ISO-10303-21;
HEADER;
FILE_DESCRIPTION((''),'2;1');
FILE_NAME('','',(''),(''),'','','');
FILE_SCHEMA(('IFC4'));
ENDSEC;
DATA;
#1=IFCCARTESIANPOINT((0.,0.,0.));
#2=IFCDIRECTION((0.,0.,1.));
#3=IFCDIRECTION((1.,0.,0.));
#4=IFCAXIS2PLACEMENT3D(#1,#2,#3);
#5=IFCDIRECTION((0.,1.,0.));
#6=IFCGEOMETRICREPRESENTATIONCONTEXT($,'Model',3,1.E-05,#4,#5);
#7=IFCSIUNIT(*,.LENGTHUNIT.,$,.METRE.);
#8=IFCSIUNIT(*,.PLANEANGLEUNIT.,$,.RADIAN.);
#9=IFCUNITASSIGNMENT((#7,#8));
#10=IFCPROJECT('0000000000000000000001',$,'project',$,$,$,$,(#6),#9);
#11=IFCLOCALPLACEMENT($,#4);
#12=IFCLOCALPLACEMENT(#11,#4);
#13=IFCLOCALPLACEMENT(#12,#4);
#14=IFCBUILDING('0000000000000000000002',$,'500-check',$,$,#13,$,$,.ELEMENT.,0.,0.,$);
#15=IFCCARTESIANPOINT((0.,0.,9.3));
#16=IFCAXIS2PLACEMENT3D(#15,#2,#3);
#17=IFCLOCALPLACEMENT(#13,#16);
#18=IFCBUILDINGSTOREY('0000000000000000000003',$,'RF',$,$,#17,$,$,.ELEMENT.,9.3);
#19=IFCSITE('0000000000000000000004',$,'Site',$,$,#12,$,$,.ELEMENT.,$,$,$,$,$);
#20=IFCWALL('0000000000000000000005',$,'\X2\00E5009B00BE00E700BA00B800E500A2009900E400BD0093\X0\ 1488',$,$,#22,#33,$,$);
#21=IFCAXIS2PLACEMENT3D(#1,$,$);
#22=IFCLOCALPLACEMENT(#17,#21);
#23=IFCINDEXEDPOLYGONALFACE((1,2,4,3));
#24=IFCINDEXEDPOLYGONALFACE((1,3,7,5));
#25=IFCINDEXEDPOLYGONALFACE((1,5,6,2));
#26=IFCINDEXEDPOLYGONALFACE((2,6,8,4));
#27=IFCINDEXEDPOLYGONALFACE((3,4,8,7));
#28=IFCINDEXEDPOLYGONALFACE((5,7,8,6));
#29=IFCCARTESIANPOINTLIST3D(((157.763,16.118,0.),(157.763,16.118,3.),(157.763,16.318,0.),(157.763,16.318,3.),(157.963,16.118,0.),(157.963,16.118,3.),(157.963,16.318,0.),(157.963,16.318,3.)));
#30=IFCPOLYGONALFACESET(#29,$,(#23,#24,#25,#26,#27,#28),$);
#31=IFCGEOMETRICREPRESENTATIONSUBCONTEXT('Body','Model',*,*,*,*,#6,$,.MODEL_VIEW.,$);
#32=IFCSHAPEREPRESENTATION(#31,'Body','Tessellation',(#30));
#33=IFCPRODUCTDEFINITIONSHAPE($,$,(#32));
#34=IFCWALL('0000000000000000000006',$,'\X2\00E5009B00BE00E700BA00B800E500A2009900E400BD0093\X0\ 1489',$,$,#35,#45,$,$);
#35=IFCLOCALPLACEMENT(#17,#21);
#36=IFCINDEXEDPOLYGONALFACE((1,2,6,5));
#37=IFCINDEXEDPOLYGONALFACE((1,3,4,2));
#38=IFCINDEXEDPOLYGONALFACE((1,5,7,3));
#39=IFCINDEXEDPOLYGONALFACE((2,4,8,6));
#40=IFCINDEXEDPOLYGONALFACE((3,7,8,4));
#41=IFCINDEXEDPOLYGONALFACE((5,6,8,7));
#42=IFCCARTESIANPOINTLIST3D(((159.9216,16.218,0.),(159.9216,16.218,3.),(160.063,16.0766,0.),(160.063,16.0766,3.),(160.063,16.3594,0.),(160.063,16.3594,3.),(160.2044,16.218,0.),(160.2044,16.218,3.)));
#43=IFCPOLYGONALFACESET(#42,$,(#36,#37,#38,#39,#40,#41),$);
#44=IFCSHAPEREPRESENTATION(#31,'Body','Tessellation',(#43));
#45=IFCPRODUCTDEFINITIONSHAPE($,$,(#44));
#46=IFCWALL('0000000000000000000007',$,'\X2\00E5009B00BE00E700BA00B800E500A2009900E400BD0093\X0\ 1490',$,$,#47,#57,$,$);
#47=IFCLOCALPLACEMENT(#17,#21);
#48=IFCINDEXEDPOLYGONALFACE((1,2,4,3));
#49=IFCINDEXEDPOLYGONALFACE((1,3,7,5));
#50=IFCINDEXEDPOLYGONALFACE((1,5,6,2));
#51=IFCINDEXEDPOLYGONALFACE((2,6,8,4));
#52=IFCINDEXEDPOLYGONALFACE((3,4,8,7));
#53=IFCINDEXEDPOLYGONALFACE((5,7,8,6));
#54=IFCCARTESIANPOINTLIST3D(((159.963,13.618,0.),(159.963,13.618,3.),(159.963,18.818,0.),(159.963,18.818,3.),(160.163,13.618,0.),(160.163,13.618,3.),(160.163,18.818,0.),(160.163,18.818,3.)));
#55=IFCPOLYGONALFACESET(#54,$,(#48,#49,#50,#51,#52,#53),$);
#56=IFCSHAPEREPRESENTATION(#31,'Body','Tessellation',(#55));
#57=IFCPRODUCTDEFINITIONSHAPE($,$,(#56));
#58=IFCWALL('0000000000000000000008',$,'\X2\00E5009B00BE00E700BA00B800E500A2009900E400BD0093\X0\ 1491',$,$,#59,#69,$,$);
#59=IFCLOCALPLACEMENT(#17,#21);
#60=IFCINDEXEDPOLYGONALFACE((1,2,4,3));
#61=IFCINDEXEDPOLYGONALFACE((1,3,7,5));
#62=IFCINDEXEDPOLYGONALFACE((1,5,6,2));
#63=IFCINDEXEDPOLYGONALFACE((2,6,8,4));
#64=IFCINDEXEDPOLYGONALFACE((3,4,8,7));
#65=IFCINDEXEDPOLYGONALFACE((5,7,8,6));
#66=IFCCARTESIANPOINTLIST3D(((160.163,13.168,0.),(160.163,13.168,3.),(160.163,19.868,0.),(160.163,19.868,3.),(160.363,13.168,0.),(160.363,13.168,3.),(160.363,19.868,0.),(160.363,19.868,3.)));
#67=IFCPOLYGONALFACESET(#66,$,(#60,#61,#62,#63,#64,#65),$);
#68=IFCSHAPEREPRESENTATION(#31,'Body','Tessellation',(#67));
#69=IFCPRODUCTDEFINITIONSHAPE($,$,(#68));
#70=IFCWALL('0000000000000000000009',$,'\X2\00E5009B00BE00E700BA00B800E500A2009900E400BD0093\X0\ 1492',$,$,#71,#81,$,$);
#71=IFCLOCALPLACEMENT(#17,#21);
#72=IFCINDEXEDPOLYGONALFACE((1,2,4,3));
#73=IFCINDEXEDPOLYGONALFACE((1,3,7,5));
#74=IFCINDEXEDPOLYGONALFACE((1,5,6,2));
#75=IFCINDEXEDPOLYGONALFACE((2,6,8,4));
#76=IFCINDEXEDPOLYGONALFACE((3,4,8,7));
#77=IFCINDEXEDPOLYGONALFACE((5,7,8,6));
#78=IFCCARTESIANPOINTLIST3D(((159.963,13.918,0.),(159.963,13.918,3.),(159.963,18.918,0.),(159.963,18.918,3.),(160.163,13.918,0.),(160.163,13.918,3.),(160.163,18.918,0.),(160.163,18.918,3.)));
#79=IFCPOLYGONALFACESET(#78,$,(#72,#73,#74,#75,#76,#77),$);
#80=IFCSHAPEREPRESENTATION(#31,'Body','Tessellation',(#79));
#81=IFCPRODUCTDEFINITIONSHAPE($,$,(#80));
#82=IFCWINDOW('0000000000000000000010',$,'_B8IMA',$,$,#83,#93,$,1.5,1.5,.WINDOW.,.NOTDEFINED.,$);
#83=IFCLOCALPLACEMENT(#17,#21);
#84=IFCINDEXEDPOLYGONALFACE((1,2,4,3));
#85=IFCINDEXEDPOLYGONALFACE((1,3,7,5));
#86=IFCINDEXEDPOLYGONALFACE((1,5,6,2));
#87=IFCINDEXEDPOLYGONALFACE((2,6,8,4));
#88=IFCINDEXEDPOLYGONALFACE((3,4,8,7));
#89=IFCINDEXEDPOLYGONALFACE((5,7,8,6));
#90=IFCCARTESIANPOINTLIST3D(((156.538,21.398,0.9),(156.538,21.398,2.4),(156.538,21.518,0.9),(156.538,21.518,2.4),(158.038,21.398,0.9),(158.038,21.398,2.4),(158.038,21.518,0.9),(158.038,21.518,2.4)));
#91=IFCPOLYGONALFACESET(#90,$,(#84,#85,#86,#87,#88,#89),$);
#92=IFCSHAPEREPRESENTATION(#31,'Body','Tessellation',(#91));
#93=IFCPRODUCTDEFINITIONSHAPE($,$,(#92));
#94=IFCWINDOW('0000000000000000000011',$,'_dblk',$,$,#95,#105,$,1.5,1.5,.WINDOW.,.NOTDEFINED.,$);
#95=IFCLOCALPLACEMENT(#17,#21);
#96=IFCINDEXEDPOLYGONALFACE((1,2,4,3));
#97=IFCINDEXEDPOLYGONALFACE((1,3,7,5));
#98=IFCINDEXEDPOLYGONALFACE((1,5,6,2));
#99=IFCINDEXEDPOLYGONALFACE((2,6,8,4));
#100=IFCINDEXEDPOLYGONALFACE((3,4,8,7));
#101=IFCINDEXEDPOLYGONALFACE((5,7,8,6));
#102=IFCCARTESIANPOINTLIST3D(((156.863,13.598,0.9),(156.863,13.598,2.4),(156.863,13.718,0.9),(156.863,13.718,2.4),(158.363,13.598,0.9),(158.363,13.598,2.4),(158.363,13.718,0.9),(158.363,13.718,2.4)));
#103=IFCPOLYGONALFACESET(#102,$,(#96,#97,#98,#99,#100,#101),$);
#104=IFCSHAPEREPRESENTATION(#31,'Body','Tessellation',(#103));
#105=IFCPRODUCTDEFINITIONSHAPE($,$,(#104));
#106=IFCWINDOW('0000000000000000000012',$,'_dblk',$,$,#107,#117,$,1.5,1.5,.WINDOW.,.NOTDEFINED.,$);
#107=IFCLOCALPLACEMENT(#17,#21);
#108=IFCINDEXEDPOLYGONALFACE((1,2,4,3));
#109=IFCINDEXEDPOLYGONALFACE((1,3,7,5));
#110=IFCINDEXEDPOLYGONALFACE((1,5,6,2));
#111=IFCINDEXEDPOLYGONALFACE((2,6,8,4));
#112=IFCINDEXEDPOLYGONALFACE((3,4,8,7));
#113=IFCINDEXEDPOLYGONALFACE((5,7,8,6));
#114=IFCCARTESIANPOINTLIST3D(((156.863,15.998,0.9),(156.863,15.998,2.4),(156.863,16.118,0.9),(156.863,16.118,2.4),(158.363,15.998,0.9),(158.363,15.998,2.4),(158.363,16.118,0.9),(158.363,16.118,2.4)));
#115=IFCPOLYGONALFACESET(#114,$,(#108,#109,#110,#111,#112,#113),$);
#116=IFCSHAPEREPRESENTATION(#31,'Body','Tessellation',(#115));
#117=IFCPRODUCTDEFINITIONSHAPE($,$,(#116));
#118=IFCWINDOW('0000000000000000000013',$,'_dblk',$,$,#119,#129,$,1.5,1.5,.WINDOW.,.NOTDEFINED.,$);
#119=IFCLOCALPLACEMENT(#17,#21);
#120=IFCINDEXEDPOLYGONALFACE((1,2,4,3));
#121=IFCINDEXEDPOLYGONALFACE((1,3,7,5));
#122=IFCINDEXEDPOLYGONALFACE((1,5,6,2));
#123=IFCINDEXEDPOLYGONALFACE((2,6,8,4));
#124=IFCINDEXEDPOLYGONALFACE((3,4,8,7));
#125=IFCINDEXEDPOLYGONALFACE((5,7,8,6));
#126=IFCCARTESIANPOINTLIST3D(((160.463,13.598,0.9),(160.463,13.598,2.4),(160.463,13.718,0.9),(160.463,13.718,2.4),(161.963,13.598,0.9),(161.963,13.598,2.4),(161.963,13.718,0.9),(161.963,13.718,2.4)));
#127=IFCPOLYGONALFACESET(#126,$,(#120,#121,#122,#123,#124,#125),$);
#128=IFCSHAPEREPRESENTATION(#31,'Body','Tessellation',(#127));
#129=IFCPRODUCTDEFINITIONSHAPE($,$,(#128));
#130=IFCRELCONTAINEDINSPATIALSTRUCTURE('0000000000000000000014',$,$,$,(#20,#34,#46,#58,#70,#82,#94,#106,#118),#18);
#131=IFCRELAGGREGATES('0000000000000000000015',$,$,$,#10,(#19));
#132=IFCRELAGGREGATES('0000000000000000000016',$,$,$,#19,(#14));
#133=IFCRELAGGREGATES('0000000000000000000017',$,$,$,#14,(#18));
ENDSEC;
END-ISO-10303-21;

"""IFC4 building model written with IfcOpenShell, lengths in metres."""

from ifc_helpers import new_model, si_unit, direction, frame, frame_2d, origin_with_axes, place, context, subcontext, project, spatial, rectangle, extrude, element, save


model = new_model("IFC4")

# Units and contexts
model_context = context("Model", 3, precision=1e-05, world=origin_with_axes(), true_north=direction((0.0, 1.0, 0.0)))
body_context = subcontext(model_context, "Body", "Model", "MODEL_VIEW")
ifc_project = project(units=[si_unit("LENGTHUNIT", "METRE"), si_unit("PLANEANGLEUNIT", "RADIAN")], contexts=[model_context])

# Site, building, storey
placement = place(None, origin_with_axes())
site_placement = place(placement, origin_with_axes())
site = spatial("IfcSite", under=ifc_project, at=site_placement, Name="Site", CompositionType="ELEMENT")
building_placement = place(site_placement, origin_with_axes())
building = spatial("IfcBuilding", under=site, at=building_placement, Name="500-check", CompositionType="ELEMENT", ElevationOfRefHeight=0.0, ElevationOfTerrain=0.0)
storey_placement = place(building_placement, frame((0.0, 0.0, 9.3), z_axis=(0.0, 0.0, 1.0), x_axis=(1.0, 0.0, 0.0)))
storey = spatial("IfcBuildingStorey", under=building, at=storey_placement, Name="RF", CompositionType="ELEMENT", Elevation=9.3)

# Walls
for number, where, z_axis, x_axis, name in (
    (1, (157.863, 16.218, 0.0), (0.0, 0.0, 1.0), (0.0, -1.0, 0.0), "å\u009b¾çº¸å¢\u0099ä½\u0093 1488"),
    (2, (160.063, 16.218, 0.0), (0.0, 0.0, 1.0), (-0.707107, -0.707107, 0.0), "å\u009b¾çº¸å¢\u0099ä½\u0093 1489"),
):
    element("IfcWall", number, at=place(storey_placement, frame(where, z_axis=z_axis, x_axis=x_axis)), inside=storey, Name=name, context=body_context, shape_type="SweptSolid", body=[
        extrude(rectangle(XDim=0.2, YDim=0.2, at=frame_2d((0.0, 0.0), x_axis=(1.0, 0.0, 0.0))), frame((0.0, 0.0, 0.0), z_axis=(0.0, 0.0, 1.0)), (0.0, 0.0, 1.0), 3.0),
    ])
wall_1_placement = place(storey_placement, frame((160.063, 16.218, 0.0), z_axis=(0.0, 0.0, 1.0), x_axis=(0.0, 1.0, 0.0)))
element("IfcWall", 3, at=wall_1_placement, inside=storey, Name="å\u009b¾çº¸å¢\u0099ä½\u0093 1490", context=body_context, shape_type="SweptSolid", body=[
    extrude(rectangle(XDim=5.2, YDim=0.2, at=frame_2d((0.0, 0.0), x_axis=(1.0, 0.0, 0.0))), frame((0.0, 0.0, 0.0), z_axis=(0.0, 0.0, 1.0)), (0.0, 0.0, 1.0), 3.0),
])
wall_2_placement = place(storey_placement, frame((160.263, 16.518, 0.0), z_axis=(0.0, 0.0, 1.0), x_axis=(0.0, 1.0, 0.0)))
element("IfcWall", 4, at=wall_2_placement, inside=storey, Name="å\u009b¾çº¸å¢\u0099ä½\u0093 1491", context=body_context, shape_type="SweptSolid", body=[
    extrude(rectangle(XDim=6.7, YDim=0.2, at=frame_2d((0.0, 0.0), x_axis=(1.0, 0.0, 0.0))), frame((0.0, 0.0, 0.0), z_axis=(0.0, 0.0, 1.0)), (0.0, 0.0, 1.0), 3.0),
])
wall_3_placement = place(storey_placement, frame((160.063, 16.418, 0.0), z_axis=(0.0, 0.0, 1.0), x_axis=(0.0, 1.0, 0.0)))
element("IfcWall", 5, at=wall_3_placement, inside=storey, Name="å\u009b¾çº¸å¢\u0099ä½\u0093 1492", context=body_context, shape_type="SweptSolid", body=[
    extrude(rectangle(XDim=5.0, YDim=0.2, at=frame_2d((0.0, 0.0), x_axis=(1.0, 0.0, 0.0))), frame((0.0, 0.0, 0.0), z_axis=(0.0, 0.0, 1.0)), (0.0, 0.0, 1.0), 3.0),
])

# Windows
for number, where, z_axis, x_axis, name in (
    (6, (157.288, 21.458, 0.9), (0.0, 0.0, 1.0), (1.0, 0.0, 0.0), "_B8IMA"),
    (7, (157.613, 13.658, 0.9), (0.0, 0.0, 1.0), (1.0, 0.0, 0.0), "_dblk"),
    (8, (157.613, 16.058, 0.9), (0.0, 0.0, 1.0), (1.0, 0.0, 0.0), "_dblk"),
    (9, (161.213, 13.658, 0.9), (0.0, 0.0, 1.0), (1.0, 0.0, 0.0), "_dblk"),
):
    element("IfcWindow", number, at=place(storey_placement, frame(where, z_axis=z_axis, x_axis=x_axis)), inside=storey, Name=name, OverallHeight=1.5, OverallWidth=1.5, PartitioningType="NOTDEFINED", PredefinedType="WINDOW", context=body_context, shape_type="SweptSolid", body=[
        extrude(rectangle(XDim=1.5, YDim=0.12, at=frame_2d((0.0, 0.0), x_axis=(1.0, 0.0, 0.0))), frame((0.0, 0.0, 0.0), z_axis=(0.0, 0.0, 1.0)), (0.0, 0.0, 1.0), 1.5),
    ])

save(model, "model.ifc")
